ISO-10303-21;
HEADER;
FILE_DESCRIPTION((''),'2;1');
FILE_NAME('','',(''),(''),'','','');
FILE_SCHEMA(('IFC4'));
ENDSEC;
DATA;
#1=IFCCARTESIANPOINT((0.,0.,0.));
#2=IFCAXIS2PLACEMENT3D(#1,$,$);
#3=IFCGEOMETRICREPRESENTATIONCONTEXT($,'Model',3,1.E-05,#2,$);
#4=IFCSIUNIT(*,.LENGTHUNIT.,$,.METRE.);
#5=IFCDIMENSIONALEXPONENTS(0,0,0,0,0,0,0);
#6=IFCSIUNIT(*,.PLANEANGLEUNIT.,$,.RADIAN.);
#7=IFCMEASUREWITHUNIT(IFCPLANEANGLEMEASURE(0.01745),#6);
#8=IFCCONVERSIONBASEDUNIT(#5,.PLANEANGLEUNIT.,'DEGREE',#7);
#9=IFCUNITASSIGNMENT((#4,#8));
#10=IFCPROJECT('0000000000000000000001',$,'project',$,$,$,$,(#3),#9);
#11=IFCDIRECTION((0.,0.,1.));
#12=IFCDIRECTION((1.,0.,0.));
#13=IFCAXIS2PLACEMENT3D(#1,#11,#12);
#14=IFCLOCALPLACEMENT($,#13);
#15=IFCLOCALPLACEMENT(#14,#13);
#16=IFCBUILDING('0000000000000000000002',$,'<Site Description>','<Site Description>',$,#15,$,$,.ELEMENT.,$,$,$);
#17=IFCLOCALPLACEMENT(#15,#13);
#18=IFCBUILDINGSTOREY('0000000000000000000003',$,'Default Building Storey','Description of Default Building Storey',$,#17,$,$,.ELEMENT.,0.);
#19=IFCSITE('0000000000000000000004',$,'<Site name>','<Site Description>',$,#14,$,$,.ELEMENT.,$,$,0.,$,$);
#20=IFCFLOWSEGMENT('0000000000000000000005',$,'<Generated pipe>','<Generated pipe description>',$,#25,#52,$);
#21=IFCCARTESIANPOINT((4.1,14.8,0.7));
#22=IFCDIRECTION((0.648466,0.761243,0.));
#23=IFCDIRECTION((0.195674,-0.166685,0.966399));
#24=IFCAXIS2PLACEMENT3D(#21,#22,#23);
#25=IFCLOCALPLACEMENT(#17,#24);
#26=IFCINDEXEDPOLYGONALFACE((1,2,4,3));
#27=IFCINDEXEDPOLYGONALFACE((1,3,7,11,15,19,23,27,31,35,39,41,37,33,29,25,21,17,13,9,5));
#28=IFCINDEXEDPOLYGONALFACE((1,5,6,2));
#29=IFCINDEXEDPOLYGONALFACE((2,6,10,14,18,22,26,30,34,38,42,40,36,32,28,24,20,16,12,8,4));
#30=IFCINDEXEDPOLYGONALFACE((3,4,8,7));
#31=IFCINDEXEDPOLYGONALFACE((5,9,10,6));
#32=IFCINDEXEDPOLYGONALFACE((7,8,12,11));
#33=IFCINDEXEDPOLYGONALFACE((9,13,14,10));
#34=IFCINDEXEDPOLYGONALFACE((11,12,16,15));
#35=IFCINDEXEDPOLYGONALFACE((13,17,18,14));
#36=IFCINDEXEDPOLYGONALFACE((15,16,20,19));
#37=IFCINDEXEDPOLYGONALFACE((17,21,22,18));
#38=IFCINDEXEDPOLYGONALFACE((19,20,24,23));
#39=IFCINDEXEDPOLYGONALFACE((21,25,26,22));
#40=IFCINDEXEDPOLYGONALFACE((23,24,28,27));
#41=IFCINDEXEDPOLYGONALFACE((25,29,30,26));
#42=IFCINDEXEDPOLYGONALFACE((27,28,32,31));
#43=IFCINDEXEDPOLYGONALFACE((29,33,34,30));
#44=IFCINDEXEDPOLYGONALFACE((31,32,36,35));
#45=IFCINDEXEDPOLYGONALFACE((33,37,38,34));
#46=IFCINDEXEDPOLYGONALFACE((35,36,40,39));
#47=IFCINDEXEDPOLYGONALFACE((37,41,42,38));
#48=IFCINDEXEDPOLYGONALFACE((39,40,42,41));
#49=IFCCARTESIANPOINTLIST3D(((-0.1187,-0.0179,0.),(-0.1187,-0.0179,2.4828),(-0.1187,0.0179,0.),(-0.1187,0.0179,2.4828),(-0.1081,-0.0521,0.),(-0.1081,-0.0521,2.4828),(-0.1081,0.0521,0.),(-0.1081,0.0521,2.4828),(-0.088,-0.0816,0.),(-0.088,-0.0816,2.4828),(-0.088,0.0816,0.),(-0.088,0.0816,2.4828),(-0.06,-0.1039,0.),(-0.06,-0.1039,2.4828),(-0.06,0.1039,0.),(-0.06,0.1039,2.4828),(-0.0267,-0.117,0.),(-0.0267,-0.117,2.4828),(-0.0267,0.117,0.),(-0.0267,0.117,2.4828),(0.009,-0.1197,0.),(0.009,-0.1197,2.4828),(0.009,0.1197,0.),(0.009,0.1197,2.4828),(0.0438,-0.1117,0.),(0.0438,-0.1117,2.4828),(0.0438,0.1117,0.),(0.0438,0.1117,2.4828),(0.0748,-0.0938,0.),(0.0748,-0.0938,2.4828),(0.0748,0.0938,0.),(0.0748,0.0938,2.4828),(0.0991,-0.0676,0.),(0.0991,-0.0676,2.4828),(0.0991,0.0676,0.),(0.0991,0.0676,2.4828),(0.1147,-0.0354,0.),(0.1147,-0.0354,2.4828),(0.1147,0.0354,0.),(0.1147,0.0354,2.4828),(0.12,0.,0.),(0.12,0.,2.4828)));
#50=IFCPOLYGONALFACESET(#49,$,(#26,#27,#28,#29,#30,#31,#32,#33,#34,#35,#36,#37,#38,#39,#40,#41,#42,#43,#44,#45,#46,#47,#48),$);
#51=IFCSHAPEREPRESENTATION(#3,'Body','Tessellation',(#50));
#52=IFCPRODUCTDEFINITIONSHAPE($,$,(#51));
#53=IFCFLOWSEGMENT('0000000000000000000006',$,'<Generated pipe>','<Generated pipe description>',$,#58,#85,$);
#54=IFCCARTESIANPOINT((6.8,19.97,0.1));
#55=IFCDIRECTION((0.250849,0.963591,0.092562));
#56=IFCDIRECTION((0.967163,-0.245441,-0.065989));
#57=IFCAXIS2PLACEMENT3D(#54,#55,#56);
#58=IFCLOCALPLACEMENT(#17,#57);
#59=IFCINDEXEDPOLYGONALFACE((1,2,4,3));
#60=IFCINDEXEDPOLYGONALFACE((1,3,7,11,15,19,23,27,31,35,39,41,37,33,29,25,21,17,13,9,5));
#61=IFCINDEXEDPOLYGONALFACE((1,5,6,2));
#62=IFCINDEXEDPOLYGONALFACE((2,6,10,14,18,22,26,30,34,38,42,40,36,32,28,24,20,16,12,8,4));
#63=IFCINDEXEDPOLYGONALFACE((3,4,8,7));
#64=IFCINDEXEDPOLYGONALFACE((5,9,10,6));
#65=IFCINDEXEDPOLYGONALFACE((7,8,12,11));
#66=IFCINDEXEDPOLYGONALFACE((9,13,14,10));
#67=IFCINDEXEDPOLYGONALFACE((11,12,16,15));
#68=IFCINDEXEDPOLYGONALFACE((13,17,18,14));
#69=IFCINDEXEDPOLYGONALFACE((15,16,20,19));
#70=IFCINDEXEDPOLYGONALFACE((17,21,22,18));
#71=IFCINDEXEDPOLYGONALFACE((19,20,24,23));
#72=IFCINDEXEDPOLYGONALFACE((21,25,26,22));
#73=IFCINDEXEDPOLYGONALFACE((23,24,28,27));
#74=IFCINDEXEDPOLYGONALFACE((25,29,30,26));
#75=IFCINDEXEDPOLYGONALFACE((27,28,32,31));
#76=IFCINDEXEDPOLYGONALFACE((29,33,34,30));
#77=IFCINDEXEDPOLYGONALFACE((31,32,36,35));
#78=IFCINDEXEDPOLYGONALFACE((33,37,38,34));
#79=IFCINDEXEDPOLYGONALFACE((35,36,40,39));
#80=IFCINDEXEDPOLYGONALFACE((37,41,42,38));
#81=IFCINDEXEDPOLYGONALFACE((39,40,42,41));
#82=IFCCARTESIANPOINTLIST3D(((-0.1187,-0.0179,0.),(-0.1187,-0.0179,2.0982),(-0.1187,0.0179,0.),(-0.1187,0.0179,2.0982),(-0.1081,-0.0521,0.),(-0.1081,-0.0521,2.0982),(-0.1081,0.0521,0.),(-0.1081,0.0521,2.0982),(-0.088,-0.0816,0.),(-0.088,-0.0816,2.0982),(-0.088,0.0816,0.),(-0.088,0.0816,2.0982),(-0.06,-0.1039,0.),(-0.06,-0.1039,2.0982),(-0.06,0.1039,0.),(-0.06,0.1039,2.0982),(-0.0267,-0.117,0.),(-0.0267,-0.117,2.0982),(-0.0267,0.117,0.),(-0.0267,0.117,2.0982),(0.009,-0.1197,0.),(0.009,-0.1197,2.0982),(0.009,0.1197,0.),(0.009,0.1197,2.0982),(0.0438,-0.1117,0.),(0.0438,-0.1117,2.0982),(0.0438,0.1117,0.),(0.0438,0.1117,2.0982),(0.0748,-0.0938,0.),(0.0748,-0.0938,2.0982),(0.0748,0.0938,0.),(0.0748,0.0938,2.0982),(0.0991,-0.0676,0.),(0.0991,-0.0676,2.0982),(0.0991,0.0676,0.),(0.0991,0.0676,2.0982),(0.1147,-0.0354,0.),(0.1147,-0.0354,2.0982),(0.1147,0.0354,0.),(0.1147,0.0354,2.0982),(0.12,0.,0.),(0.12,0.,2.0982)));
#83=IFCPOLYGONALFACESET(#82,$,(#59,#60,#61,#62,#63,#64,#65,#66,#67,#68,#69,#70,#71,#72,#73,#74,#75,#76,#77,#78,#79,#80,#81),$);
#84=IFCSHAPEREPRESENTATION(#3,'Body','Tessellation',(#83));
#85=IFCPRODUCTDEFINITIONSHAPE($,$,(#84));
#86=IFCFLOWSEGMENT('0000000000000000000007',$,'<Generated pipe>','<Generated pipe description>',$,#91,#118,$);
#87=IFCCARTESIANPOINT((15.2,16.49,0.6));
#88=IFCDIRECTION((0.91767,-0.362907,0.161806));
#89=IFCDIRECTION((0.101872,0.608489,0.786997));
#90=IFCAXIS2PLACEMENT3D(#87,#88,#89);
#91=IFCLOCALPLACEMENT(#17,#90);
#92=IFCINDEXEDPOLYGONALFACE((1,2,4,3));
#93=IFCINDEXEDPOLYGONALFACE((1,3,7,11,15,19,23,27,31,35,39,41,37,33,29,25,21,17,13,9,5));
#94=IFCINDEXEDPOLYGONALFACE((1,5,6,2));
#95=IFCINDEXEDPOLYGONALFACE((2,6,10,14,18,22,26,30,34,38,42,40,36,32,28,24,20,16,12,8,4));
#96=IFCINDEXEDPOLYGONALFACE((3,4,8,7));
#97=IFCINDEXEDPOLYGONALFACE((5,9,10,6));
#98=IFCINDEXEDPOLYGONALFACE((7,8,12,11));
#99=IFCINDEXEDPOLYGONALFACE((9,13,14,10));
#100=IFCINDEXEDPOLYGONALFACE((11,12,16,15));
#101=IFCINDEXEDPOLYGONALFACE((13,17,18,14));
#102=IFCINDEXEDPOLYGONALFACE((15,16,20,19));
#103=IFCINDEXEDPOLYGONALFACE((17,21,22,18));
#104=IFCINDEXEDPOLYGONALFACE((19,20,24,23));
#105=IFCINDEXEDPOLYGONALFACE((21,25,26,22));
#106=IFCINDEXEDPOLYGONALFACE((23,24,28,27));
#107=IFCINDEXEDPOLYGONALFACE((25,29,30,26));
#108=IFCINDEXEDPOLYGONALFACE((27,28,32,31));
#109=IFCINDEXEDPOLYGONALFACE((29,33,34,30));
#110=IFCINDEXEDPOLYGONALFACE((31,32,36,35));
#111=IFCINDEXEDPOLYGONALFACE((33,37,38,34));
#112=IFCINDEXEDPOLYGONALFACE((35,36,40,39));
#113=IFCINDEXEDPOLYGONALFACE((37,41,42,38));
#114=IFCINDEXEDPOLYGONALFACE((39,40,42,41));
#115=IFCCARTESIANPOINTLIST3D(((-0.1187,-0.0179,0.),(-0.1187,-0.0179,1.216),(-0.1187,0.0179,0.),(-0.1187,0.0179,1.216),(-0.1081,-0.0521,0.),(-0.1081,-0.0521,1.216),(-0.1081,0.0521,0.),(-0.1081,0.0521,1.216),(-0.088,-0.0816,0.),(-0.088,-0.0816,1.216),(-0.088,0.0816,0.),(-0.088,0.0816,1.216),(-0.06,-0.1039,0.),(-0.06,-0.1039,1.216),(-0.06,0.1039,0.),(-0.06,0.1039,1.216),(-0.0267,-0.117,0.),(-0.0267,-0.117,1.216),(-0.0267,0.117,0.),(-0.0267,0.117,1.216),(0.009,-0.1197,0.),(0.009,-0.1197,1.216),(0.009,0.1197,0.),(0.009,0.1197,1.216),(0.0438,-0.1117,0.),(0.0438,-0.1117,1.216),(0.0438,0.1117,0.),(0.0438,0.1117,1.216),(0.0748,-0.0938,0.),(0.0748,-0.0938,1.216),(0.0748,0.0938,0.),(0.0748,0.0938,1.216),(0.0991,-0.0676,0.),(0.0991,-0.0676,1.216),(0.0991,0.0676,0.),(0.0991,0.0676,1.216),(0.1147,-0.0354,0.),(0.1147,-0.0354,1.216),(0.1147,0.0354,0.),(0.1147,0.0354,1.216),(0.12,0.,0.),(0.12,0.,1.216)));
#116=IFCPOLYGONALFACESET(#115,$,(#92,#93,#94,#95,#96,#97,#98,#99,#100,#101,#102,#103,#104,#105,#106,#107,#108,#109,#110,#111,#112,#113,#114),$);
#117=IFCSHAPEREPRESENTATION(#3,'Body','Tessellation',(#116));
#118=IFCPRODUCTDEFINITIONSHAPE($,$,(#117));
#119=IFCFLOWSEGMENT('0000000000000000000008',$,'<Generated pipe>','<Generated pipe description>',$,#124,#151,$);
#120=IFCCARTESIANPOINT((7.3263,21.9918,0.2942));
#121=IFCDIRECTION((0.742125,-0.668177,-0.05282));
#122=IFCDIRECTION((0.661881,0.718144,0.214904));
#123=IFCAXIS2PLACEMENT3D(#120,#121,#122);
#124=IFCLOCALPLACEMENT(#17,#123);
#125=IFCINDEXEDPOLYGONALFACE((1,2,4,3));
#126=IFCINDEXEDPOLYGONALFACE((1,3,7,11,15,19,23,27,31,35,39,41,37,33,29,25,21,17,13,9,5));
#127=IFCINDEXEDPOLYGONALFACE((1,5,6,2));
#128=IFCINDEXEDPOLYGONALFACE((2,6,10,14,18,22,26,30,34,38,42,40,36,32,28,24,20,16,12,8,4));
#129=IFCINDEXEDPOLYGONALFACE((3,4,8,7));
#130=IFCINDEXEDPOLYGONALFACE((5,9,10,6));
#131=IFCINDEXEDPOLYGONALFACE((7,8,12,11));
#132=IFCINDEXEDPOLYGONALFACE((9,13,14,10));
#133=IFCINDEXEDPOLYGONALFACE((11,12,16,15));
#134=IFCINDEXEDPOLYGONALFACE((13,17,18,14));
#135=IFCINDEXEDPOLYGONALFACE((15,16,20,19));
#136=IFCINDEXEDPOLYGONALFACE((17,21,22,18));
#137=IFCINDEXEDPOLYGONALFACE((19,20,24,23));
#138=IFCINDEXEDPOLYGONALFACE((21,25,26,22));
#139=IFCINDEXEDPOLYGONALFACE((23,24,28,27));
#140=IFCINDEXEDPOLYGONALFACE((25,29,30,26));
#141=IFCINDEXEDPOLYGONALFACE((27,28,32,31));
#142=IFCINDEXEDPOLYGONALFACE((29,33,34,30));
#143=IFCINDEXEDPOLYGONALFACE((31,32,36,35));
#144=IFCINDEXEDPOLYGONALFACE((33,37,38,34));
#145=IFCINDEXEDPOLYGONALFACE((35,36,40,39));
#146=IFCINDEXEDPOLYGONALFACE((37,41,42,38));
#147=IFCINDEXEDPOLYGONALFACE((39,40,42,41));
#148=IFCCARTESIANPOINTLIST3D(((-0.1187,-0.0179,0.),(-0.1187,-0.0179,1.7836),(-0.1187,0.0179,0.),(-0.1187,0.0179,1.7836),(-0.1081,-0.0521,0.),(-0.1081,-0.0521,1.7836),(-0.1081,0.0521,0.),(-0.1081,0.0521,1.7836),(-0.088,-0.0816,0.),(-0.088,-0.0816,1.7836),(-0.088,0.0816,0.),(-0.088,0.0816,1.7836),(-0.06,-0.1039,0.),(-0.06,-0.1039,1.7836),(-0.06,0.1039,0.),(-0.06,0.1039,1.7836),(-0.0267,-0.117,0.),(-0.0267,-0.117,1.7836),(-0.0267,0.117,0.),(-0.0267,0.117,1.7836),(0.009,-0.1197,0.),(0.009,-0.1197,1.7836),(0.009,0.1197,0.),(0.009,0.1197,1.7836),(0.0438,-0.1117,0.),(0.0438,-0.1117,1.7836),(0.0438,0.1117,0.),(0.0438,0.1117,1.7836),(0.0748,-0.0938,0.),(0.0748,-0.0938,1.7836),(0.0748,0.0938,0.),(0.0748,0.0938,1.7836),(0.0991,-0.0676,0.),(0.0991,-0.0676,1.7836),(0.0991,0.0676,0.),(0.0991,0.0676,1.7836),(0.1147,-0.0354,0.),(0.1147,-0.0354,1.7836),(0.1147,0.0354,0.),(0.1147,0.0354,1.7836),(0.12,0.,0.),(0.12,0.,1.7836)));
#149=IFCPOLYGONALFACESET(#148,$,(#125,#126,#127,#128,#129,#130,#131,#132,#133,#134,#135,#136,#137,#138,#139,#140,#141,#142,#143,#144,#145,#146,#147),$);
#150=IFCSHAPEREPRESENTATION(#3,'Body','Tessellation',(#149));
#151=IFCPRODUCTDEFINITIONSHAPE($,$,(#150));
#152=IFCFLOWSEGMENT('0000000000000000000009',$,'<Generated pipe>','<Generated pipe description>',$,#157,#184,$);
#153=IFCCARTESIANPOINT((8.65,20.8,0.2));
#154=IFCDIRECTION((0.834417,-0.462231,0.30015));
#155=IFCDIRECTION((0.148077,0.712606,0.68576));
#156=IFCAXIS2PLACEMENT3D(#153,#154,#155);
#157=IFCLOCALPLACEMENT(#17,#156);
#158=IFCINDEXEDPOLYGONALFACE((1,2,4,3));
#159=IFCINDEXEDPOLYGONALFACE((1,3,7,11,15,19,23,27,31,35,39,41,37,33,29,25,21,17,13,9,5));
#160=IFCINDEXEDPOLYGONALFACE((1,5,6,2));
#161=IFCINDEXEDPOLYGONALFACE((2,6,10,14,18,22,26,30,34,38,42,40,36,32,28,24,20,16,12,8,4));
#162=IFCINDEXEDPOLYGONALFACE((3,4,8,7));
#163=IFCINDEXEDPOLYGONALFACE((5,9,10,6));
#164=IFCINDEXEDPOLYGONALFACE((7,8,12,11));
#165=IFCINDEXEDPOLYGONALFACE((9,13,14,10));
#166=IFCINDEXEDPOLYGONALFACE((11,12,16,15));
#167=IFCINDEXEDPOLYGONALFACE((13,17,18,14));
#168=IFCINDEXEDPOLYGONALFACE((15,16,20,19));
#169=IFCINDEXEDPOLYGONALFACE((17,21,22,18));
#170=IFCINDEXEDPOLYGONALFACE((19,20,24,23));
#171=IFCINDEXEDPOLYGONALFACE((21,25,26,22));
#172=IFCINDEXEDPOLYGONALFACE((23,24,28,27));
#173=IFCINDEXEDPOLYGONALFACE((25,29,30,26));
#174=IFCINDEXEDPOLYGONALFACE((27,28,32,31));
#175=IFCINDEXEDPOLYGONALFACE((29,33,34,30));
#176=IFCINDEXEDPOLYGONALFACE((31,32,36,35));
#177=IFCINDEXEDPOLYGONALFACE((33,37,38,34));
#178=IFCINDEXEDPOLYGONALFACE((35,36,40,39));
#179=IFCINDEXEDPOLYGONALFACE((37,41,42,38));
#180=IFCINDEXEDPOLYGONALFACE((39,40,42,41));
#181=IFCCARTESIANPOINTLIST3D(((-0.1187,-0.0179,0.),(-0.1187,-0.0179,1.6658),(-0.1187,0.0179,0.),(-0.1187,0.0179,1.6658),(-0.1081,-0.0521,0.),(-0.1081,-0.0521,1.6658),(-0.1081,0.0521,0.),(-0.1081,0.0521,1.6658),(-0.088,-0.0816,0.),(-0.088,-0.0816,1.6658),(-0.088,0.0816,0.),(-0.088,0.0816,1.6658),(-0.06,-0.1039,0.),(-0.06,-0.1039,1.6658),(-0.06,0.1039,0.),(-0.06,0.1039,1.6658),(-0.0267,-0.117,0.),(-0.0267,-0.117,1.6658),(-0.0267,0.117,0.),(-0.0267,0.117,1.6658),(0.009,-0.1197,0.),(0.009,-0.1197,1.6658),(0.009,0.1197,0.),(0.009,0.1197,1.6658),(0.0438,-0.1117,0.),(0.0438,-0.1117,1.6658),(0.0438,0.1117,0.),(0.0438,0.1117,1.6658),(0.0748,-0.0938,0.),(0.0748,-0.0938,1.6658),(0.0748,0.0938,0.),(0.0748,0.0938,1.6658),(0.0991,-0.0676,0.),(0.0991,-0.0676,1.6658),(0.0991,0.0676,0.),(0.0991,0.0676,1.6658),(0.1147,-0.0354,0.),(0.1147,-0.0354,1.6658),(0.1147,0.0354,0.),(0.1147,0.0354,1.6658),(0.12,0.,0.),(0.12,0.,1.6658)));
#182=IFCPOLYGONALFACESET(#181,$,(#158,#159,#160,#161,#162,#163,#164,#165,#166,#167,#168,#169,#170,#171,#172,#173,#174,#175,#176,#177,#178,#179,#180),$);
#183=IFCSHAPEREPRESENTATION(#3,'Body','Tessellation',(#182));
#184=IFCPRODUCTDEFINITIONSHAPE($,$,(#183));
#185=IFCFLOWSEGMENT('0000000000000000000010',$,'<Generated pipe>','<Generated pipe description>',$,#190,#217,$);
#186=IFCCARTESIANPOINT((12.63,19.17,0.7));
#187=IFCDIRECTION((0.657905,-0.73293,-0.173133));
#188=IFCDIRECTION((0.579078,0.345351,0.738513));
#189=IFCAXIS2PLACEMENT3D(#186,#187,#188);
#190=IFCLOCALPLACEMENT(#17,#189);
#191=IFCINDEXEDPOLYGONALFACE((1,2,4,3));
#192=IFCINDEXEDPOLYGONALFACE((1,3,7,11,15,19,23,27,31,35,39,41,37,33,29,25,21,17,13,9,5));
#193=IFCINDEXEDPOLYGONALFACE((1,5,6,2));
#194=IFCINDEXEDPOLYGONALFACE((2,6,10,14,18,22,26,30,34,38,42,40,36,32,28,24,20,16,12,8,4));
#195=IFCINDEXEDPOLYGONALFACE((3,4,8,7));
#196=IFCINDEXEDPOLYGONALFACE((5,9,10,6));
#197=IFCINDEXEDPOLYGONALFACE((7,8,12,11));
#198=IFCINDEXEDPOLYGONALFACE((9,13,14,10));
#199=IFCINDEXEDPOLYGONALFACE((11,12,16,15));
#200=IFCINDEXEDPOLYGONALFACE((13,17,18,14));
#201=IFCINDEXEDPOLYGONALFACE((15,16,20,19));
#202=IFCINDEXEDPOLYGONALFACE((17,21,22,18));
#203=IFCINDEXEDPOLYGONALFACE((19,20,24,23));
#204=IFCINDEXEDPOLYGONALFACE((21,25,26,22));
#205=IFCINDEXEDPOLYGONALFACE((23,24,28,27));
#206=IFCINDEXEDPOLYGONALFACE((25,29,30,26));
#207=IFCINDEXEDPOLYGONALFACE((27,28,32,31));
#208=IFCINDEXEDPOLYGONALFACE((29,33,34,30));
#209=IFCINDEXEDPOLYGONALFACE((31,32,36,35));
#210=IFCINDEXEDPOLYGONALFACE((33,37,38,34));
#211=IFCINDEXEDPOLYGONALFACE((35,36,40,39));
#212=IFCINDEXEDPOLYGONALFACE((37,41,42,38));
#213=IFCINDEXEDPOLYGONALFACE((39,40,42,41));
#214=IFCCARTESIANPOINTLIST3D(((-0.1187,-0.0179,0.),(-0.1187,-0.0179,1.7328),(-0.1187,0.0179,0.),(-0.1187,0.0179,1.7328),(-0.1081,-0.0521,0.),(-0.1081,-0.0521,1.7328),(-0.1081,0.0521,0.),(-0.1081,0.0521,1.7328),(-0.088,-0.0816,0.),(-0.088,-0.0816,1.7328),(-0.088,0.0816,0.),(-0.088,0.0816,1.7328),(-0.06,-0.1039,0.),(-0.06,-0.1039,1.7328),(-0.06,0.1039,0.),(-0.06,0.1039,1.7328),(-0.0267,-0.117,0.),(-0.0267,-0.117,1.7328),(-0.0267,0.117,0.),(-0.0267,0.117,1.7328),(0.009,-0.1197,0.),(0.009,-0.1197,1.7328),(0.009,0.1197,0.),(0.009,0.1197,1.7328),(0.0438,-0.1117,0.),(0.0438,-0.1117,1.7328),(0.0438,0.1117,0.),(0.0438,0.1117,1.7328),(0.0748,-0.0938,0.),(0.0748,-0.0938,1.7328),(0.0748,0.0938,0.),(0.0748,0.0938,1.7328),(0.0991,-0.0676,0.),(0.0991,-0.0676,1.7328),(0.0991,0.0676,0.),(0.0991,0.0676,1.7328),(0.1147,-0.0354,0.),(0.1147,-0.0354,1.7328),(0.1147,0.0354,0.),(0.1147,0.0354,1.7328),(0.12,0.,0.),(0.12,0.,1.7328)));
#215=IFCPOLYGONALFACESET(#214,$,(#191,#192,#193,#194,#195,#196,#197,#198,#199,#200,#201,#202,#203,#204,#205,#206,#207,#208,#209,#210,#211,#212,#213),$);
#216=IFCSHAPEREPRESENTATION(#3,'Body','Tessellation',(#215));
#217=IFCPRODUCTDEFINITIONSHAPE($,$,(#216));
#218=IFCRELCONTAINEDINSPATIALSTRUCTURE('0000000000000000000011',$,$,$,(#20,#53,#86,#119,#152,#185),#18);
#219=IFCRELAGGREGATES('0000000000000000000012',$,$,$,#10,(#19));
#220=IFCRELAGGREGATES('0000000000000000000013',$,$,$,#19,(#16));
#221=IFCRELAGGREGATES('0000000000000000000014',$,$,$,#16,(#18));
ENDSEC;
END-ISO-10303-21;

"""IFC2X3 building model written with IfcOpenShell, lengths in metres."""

from ifc_helpers import new_model, entity, si_unit, converted_unit, frame, origin, origin_with_axes, origin_2d_with_axis, place, context, project, spatial, circle, extrude, element, save


model = new_model("IFC2X3")

# Units and contexts
model_context = context("Model", 3, precision=1e-05, world=origin())
ifc_project = project(units=[si_unit("LENGTHUNIT", "METRE"), converted_unit("PLANEANGLEUNIT", "DEGREE", entity("IfcPlaneAngleMeasure", 0.01745), si_unit("PLANEANGLEUNIT", "RADIAN"), dimensions=[0, 0, 0, 0, 0, 0, 0])], contexts=[model_context])

# Site, building, storey
site_placement = place(None, origin_with_axes())
site = spatial("IfcSite", under=ifc_project, at=site_placement, Name="<Site name>", Description="<Site Description>", CompositionType="ELEMENT", RefElevation=0.0)
building_placement = place(site_placement, origin_with_axes())
building = spatial("IfcBuilding", under=site, at=building_placement, Name="<Site Description>", Description="<Site Description>", CompositionType="ELEMENT")
storey_placement = place(building_placement, origin_with_axes())
storey = spatial("IfcBuildingStorey", under=building, at=storey_placement, Name="Default Building Storey", Description="Description of Default Building Storey", CompositionType="ELEMENT", Elevation=0.0)

# Flow segments
flow_segment_1_placement = place(storey_placement, frame((4.1, 14.8, 0.7), z_axis=(0.648466, 0.761243, 0.0), x_axis=(0.195674, -0.166685, 0.966399)))
element("IfcFlowSegment", 1, at=flow_segment_1_placement, inside=storey, Name="<Generated pipe>", Description="<Generated pipe description>", context=model_context, shape_type="SweptSolid", body=[
    extrude(circle(Radius=0.12, at=origin_2d_with_axis()), origin_with_axes(), (0.0, 0.0, 1.0), 2.4828),
])
flow_segment_2_placement = place(storey_placement, frame((6.8, 19.97, 0.1), z_axis=(0.250849, 0.963591, 0.092562), x_axis=(0.967163, -0.245441, -0.065989)))
element("IfcFlowSegment", 2, at=flow_segment_2_placement, inside=storey, Name="<Generated pipe>", Description="<Generated pipe description>", context=model_context, shape_type="SweptSolid", body=[
    extrude(circle(Radius=0.12, at=origin_2d_with_axis()), origin_with_axes(), (0.0, 0.0, 1.0), 2.0982),
])
flow_segment_3_placement = place(storey_placement, frame((15.2, 16.49, 0.6), z_axis=(0.91767, -0.362907, 0.161806), x_axis=(0.101872, 0.608489, 0.786997)))
element("IfcFlowSegment", 3, at=flow_segment_3_placement, inside=storey, Name="<Generated pipe>", Description="<Generated pipe description>", context=model_context, shape_type="SweptSolid", body=[
    extrude(circle(Radius=0.12, at=origin_2d_with_axis()), origin_with_axes(), (0.0, 0.0, 1.0), 1.216),
])
flow_segment_4_placement = place(storey_placement, frame((7.3263, 21.9918, 0.2942), z_axis=(0.742125, -0.668177, -0.05282), x_axis=(0.661881, 0.718144, 0.214904)))
element("IfcFlowSegment", 4, at=flow_segment_4_placement, inside=storey, Name="<Generated pipe>", Description="<Generated pipe description>", context=model_context, shape_type="SweptSolid", body=[
    extrude(circle(Radius=0.12, at=origin_2d_with_axis()), origin_with_axes(), (0.0, 0.0, 1.0), 1.7836),
])
flow_segment_5_placement = place(storey_placement, frame((8.65, 20.8, 0.2), z_axis=(0.834417, -0.462231, 0.30015), x_axis=(0.148077, 0.712606, 0.68576)))
element("IfcFlowSegment", 5, at=flow_segment_5_placement, inside=storey, Name="<Generated pipe>", Description="<Generated pipe description>", context=model_context, shape_type="SweptSolid", body=[
    extrude(circle(Radius=0.12, at=origin_2d_with_axis()), origin_with_axes(), (0.0, 0.0, 1.0), 1.6658),
])
flow_segment_6_placement = place(storey_placement, frame((12.63, 19.17, 0.7), z_axis=(0.657905, -0.73293, -0.173133), x_axis=(0.579078, 0.345351, 0.738513)))
element("IfcFlowSegment", 6, at=flow_segment_6_placement, inside=storey, Name="<Generated pipe>", Description="<Generated pipe description>", context=model_context, shape_type="SweptSolid", body=[
    extrude(circle(Radius=0.12, at=origin_2d_with_axis()), origin_with_axes(), (0.0, 0.0, 1.0), 1.7328),
])

save(model, "model.ifc")
